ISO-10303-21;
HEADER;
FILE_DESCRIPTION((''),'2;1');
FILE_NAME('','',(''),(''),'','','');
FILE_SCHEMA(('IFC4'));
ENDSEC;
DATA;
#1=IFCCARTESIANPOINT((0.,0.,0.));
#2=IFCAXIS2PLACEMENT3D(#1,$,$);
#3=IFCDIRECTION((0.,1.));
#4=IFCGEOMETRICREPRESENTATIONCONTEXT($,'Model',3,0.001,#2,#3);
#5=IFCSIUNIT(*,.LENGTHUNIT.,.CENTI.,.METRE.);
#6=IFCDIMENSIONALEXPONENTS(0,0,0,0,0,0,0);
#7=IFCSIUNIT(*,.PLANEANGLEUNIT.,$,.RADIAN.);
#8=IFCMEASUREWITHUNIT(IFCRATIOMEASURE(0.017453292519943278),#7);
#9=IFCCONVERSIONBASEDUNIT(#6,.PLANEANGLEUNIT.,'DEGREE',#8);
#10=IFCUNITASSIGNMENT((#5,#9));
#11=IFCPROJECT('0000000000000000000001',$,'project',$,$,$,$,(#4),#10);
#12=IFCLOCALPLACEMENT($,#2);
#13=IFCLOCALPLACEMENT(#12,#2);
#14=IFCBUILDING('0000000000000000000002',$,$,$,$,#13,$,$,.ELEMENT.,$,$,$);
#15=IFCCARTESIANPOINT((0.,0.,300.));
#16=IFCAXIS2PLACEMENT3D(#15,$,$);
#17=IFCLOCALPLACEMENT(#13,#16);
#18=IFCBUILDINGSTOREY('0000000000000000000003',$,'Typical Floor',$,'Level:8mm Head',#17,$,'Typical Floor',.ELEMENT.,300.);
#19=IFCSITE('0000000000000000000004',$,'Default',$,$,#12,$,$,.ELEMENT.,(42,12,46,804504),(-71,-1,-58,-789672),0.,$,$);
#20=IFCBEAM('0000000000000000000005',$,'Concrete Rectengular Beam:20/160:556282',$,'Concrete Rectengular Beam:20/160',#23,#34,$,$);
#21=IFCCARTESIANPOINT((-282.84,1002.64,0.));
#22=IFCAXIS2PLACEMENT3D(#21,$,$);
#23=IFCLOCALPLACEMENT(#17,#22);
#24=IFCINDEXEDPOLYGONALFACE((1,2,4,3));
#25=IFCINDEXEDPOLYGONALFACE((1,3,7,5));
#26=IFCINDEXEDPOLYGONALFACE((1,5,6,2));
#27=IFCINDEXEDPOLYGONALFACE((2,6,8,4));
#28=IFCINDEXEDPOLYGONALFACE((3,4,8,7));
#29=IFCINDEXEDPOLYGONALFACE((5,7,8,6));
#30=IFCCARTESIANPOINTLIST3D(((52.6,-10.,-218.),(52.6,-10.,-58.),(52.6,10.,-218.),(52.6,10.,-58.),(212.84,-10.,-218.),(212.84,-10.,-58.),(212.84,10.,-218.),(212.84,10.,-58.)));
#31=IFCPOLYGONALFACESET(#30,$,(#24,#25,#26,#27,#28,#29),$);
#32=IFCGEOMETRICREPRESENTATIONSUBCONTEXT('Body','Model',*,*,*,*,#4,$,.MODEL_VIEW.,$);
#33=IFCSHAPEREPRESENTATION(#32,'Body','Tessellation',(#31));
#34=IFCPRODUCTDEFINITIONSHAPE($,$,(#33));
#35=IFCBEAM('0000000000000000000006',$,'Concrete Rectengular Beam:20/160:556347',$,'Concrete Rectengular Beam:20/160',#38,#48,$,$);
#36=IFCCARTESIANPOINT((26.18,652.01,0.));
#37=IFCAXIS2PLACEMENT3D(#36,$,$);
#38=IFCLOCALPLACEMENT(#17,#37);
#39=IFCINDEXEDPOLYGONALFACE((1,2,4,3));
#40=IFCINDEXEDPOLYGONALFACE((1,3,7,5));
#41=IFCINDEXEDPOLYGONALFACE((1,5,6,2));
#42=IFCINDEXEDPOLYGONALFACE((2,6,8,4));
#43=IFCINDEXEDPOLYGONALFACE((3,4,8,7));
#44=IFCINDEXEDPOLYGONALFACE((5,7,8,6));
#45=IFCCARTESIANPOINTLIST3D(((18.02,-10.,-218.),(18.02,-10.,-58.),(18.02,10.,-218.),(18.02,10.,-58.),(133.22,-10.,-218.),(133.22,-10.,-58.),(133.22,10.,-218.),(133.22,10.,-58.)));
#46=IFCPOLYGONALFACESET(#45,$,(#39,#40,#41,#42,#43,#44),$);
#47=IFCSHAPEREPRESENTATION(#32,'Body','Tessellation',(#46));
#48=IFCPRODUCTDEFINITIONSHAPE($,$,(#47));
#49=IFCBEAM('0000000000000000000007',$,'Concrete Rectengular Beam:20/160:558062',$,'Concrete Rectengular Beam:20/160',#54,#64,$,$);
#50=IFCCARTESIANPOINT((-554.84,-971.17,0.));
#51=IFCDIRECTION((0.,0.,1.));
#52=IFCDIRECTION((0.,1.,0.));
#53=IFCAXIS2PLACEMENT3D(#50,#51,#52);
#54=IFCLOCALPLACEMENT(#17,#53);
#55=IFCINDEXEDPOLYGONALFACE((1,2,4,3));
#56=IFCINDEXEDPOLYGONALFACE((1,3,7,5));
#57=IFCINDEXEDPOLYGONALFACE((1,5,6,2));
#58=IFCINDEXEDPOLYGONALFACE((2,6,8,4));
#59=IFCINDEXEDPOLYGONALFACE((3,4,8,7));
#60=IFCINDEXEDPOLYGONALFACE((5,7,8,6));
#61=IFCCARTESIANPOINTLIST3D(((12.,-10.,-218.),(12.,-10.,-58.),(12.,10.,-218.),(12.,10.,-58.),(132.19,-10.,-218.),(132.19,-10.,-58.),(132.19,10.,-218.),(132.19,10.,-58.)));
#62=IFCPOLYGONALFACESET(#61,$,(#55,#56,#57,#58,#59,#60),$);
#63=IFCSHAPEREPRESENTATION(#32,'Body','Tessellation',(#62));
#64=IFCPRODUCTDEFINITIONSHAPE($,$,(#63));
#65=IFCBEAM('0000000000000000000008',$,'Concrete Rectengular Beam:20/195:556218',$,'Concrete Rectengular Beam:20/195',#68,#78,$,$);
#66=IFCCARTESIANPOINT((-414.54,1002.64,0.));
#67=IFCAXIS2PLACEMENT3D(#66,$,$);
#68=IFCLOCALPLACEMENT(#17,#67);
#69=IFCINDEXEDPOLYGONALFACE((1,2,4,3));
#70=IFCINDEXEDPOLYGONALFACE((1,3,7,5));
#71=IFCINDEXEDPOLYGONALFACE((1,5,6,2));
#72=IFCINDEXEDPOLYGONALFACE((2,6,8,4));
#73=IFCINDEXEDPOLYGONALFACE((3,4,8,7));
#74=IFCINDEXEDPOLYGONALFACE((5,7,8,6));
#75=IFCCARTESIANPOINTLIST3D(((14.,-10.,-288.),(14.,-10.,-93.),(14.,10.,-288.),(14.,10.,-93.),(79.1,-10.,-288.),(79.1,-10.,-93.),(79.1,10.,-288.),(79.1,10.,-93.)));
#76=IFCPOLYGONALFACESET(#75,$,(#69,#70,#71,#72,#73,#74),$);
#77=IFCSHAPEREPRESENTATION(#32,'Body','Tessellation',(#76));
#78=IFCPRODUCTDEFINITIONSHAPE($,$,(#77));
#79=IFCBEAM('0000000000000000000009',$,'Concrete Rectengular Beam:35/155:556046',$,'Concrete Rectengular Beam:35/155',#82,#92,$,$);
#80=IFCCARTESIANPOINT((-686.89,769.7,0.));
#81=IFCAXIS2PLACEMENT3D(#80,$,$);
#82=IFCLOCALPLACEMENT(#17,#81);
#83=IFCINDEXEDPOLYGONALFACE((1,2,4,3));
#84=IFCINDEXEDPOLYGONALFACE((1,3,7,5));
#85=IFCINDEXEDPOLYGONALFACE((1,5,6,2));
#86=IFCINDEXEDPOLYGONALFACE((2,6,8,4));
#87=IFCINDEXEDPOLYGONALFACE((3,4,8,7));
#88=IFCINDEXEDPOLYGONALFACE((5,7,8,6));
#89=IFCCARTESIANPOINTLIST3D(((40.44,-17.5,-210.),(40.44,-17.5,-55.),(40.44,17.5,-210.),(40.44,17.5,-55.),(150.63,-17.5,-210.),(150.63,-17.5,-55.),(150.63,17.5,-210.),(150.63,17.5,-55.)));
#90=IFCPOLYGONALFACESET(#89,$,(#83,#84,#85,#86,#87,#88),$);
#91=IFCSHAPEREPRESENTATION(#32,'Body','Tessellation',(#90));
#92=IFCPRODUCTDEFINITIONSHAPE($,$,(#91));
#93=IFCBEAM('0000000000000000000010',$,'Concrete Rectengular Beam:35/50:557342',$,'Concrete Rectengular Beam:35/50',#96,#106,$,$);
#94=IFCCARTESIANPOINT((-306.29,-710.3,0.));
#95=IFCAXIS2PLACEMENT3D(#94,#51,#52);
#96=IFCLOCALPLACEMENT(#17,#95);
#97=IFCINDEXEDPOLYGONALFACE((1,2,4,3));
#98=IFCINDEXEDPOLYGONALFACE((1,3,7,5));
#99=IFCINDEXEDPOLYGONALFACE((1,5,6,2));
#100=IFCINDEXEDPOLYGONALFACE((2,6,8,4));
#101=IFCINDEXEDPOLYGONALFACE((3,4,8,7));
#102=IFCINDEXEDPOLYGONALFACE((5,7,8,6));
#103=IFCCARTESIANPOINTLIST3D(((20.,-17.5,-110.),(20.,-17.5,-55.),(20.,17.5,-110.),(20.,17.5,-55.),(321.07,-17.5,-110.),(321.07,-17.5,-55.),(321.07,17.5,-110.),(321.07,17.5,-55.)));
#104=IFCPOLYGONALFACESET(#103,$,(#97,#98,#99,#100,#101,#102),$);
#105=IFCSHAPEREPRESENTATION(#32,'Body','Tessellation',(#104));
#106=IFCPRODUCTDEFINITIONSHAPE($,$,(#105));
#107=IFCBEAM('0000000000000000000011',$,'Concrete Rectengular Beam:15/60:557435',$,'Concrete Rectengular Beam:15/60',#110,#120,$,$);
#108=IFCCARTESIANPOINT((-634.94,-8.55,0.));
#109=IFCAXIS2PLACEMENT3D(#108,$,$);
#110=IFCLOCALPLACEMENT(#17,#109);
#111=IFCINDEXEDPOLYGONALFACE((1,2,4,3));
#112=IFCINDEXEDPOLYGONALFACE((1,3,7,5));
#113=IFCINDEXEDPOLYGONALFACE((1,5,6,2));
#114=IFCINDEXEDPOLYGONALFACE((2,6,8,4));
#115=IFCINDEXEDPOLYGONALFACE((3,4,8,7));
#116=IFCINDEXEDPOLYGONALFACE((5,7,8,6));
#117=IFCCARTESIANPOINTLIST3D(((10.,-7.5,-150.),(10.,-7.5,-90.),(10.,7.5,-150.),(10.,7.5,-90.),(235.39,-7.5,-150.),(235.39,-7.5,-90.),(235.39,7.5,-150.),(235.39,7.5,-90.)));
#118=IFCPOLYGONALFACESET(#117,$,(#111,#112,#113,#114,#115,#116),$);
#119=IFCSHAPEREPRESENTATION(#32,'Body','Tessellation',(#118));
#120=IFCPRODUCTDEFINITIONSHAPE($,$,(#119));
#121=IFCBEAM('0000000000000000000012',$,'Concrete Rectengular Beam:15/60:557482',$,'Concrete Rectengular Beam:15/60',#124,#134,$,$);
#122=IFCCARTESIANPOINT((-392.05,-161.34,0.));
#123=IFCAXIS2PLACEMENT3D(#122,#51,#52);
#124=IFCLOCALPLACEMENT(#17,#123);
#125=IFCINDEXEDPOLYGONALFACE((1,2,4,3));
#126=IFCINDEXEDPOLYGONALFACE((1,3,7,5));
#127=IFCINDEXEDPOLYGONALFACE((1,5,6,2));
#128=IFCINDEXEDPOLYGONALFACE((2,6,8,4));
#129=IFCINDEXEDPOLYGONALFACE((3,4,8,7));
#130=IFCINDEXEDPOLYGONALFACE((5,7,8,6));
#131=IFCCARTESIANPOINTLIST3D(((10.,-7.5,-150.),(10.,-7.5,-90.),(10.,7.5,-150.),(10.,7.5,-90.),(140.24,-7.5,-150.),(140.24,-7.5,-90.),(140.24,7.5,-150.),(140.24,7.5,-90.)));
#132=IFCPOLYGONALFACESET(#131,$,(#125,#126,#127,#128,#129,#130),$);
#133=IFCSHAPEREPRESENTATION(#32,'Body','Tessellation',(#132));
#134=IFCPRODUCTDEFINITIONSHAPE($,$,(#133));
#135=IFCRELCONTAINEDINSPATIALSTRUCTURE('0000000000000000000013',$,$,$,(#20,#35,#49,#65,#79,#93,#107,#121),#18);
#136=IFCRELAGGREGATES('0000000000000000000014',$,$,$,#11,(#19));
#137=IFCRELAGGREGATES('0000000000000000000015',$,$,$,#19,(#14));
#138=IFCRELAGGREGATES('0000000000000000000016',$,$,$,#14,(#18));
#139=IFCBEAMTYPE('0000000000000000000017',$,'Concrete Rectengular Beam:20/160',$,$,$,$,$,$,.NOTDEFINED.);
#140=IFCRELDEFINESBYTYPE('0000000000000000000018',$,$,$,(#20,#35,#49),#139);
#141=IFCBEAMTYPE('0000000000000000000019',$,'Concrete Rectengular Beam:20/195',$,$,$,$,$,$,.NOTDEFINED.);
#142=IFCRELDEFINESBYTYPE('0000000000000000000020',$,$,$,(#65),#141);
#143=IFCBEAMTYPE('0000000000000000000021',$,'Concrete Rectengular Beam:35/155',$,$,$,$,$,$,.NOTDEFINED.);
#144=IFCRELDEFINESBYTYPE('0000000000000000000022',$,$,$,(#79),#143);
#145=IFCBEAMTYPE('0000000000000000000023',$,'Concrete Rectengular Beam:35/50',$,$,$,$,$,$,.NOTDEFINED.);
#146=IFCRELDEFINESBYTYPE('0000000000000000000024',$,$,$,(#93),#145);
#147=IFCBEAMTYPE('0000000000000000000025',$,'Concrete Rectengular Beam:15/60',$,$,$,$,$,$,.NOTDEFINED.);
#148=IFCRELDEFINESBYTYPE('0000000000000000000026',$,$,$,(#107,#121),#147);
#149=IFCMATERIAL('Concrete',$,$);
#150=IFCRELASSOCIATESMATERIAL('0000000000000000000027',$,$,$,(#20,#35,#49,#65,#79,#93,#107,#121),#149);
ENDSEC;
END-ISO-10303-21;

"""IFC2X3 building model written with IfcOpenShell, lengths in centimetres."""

from ifc_helpers import new_model, entity, si_unit, converted_unit, direction, frame, frame_2d, origin, origin_2d_with_axis, place, context, subcontext, project, spatial, rectangle, extrude, material, type_object, element, save


model = new_model("IFC2X3")

# Units and contexts
model_context = context("Model", 3, precision=0.001, world=origin(), true_north=direction((0.0, 1.0)))
body_context = subcontext(model_context, "Body", "Model", "MODEL_VIEW")
ifc_project = project(units=[si_unit("LENGTHUNIT", "METRE", prefix="CENTI"), converted_unit("PLANEANGLEUNIT", "DEGREE", entity("IfcRatioMeasure", 0.017453292519943278), si_unit("PLANEANGLEUNIT", "RADIAN"), dimensions=[0, 0, 0, 0, 0, 0, 0])], contexts=[model_context])

# Site, building, storey
site_placement = place(None, origin())
site = spatial("IfcSite", under=ifc_project, at=site_placement, Name="Default", CompositionType="ELEMENT", RefLatitude=(42, 12, 46, 804504), RefLongitude=(-71, -1, -58, -789672), RefElevation=0.0)
building_placement = place(site_placement, origin())
building = spatial("IfcBuilding", under=site, at=building_placement, CompositionType="ELEMENT")
storey_placement = place(building_placement, frame((0.0, 0.0, 300.0)))
storey = spatial("IfcBuildingStorey", under=building, at=storey_placement, Name="Typical Floor", ObjectType="Level:8mm Head", LongName="Typical Floor", CompositionType="ELEMENT", Elevation=300.0)

# Beams
ifc_material = material(Name="Concrete")
beam_type_1 = type_object("IfcBeamType", Name="Concrete Rectengular Beam:20/160", PredefinedType="NOTDEFINED")
beam_1_placement = place(storey_placement, frame((-282.84, 1002.64, 0.0)))
element("IfcBeam", 1, at=beam_1_placement, inside=storey, type_object=beam_type_1, material=ifc_material, Name="Concrete Rectengular Beam:20/160:556282", ObjectType="Concrete Rectengular Beam:20/160", context=body_context, shape_type="SweptSolid", body=[
    extrude(rectangle(XDim=160.0, YDim=20.0, at=frame_2d((0.0, 0.0), x_axis=(1.0, 0.0))), frame((52.6, 0.0, -138.0), z_axis=(1.0, 0.0, 0.0), x_axis=(0.0, 0.0, -1.0)), (0.0, 0.0, 1.0), 160.24),
])
beam_2_placement = place(storey_placement, frame((26.18, 652.01, 0.0)))
element("IfcBeam", 2, at=beam_2_placement, inside=storey, type_object=beam_type_1, material=ifc_material, Name="Concrete Rectengular Beam:20/160:556347", ObjectType="Concrete Rectengular Beam:20/160", context=body_context, shape_type="SweptSolid", body=[
    extrude(rectangle(XDim=160.0, YDim=20.0, at=frame_2d((0.0, 0.0), x_axis=(1.0, 0.0))), frame((18.02, 0.0, -138.0), z_axis=(1.0, 0.0, 0.0), x_axis=(0.0, 0.0, -1.0)), (0.0, 0.0, 1.0), 115.2),
])
beam_3_placement = place(storey_placement, frame((-554.84, -971.17, 0.0), z_axis=(0.0, 0.0, 1.0), x_axis=(0.0, 1.0, 0.0)))
element("IfcBeam", 3, at=beam_3_placement, inside=storey, type_object=beam_type_1, material=ifc_material, Name="Concrete Rectengular Beam:20/160:558062", ObjectType="Concrete Rectengular Beam:20/160", context=body_context, shape_type="SweptSolid", body=[
    extrude(rectangle(XDim=160.0, YDim=20.0, at=frame_2d((0.0, 0.0), x_axis=(1.0, 0.0))), frame((12.0, 0.0, -138.0), z_axis=(1.0, 0.0, 0.0), x_axis=(0.0, 0.0, -1.0)), (0.0, 0.0, 1.0), 120.19),
])
beam_type_2 = type_object("IfcBeamType", Name="Concrete Rectengular Beam:20/195", PredefinedType="NOTDEFINED")
beam_4_placement = place(storey_placement, frame((-414.54, 1002.64, 0.0)))
element("IfcBeam", 4, at=beam_4_placement, inside=storey, type_object=beam_type_2, material=ifc_material, Name="Concrete Rectengular Beam:20/195:556218", ObjectType="Concrete Rectengular Beam:20/195", context=body_context, shape_type="SweptSolid", body=[
    extrude(rectangle(XDim=195.0, YDim=20.0, at=frame_2d((0.0, 0.0), x_axis=(1.0, 0.0))), frame((14.0, 0.0, -190.5), z_axis=(1.0, 0.0, 0.0), x_axis=(0.0, 0.0, -1.0)), (0.0, 0.0, 1.0), 65.1),
])
beam_type_3 = type_object("IfcBeamType", Name="Concrete Rectengular Beam:35/155", PredefinedType="NOTDEFINED")
beam_5_placement = place(storey_placement, frame((-686.89, 769.7, 0.0)))
element("IfcBeam", 5, at=beam_5_placement, inside=storey, type_object=beam_type_3, material=ifc_material, Name="Concrete Rectengular Beam:35/155:556046", ObjectType="Concrete Rectengular Beam:35/155", context=body_context, shape_type="SweptSolid", body=[
    extrude(rectangle(XDim=155.0, YDim=35.0, at=frame_2d((0.0, 0.0), x_axis=(1.0, 0.0))), frame((40.44, 0.0, -132.5), z_axis=(1.0, 0.0, 0.0), x_axis=(0.0, 0.0, -1.0)), (0.0, 0.0, 1.0), 110.2),
])
beam_type_4 = type_object("IfcBeamType", Name="Concrete Rectengular Beam:35/50", PredefinedType="NOTDEFINED")
beam_6_placement = place(storey_placement, frame((-306.29, -710.3, 0.0), z_axis=(0.0, 0.0, 1.0), x_axis=(0.0, 1.0, 0.0)))
element("IfcBeam", 6, at=beam_6_placement, inside=storey, type_object=beam_type_4, material=ifc_material, Name="Concrete Rectengular Beam:35/50:557342", ObjectType="Concrete Rectengular Beam:35/50", context=body_context, shape_type="SweptSolid", body=[
    extrude(rectangle(XDim=55.0, YDim=35.0, at=origin_2d_with_axis()), frame((20.0, 0.0, -82.5), z_axis=(1.0, 0.0, 0.0), x_axis=(0.0, 0.0, -1.0)), (0.0, 0.0, 1.0), 301.07),
])
beam_type_5 = type_object("IfcBeamType", Name="Concrete Rectengular Beam:15/60", PredefinedType="NOTDEFINED")
beam_7_placement = place(storey_placement, frame((-634.94, -8.55, 0.0)))
element("IfcBeam", 7, at=beam_7_placement, inside=storey, type_object=beam_type_5, material=ifc_material, Name="Concrete Rectengular Beam:15/60:557435", ObjectType="Concrete Rectengular Beam:15/60", context=body_context, shape_type="SweptSolid", body=[
    extrude(rectangle(XDim=60.0, YDim=15.0, at=frame_2d((0.0, 0.0), x_axis=(1.0, 0.0))), frame((10.0, 0.0, -120.0), z_axis=(1.0, 0.0, 0.0), x_axis=(0.0, 0.0, -1.0)), (0.0, 0.0, 1.0), 225.39),
])
beam_8_placement = place(storey_placement, frame((-392.05, -161.34, 0.0), z_axis=(0.0, 0.0, 1.0), x_axis=(0.0, 1.0, 0.0)))
element("IfcBeam", 8, at=beam_8_placement, inside=storey, type_object=beam_type_5, material=ifc_material, Name="Concrete Rectengular Beam:15/60:557482", ObjectType="Concrete Rectengular Beam:15/60", context=body_context, shape_type="SweptSolid", body=[
    extrude(rectangle(XDim=60.0, YDim=15.0, at=frame_2d((0.0, 0.0), x_axis=(1.0, 0.0))), frame((10.0, 0.0, -120.0), z_axis=(1.0, 0.0, 0.0), x_axis=(0.0, 0.0, -1.0)), (0.0, 0.0, 1.0), 130.24),
])

save(model, "model.ifc")
